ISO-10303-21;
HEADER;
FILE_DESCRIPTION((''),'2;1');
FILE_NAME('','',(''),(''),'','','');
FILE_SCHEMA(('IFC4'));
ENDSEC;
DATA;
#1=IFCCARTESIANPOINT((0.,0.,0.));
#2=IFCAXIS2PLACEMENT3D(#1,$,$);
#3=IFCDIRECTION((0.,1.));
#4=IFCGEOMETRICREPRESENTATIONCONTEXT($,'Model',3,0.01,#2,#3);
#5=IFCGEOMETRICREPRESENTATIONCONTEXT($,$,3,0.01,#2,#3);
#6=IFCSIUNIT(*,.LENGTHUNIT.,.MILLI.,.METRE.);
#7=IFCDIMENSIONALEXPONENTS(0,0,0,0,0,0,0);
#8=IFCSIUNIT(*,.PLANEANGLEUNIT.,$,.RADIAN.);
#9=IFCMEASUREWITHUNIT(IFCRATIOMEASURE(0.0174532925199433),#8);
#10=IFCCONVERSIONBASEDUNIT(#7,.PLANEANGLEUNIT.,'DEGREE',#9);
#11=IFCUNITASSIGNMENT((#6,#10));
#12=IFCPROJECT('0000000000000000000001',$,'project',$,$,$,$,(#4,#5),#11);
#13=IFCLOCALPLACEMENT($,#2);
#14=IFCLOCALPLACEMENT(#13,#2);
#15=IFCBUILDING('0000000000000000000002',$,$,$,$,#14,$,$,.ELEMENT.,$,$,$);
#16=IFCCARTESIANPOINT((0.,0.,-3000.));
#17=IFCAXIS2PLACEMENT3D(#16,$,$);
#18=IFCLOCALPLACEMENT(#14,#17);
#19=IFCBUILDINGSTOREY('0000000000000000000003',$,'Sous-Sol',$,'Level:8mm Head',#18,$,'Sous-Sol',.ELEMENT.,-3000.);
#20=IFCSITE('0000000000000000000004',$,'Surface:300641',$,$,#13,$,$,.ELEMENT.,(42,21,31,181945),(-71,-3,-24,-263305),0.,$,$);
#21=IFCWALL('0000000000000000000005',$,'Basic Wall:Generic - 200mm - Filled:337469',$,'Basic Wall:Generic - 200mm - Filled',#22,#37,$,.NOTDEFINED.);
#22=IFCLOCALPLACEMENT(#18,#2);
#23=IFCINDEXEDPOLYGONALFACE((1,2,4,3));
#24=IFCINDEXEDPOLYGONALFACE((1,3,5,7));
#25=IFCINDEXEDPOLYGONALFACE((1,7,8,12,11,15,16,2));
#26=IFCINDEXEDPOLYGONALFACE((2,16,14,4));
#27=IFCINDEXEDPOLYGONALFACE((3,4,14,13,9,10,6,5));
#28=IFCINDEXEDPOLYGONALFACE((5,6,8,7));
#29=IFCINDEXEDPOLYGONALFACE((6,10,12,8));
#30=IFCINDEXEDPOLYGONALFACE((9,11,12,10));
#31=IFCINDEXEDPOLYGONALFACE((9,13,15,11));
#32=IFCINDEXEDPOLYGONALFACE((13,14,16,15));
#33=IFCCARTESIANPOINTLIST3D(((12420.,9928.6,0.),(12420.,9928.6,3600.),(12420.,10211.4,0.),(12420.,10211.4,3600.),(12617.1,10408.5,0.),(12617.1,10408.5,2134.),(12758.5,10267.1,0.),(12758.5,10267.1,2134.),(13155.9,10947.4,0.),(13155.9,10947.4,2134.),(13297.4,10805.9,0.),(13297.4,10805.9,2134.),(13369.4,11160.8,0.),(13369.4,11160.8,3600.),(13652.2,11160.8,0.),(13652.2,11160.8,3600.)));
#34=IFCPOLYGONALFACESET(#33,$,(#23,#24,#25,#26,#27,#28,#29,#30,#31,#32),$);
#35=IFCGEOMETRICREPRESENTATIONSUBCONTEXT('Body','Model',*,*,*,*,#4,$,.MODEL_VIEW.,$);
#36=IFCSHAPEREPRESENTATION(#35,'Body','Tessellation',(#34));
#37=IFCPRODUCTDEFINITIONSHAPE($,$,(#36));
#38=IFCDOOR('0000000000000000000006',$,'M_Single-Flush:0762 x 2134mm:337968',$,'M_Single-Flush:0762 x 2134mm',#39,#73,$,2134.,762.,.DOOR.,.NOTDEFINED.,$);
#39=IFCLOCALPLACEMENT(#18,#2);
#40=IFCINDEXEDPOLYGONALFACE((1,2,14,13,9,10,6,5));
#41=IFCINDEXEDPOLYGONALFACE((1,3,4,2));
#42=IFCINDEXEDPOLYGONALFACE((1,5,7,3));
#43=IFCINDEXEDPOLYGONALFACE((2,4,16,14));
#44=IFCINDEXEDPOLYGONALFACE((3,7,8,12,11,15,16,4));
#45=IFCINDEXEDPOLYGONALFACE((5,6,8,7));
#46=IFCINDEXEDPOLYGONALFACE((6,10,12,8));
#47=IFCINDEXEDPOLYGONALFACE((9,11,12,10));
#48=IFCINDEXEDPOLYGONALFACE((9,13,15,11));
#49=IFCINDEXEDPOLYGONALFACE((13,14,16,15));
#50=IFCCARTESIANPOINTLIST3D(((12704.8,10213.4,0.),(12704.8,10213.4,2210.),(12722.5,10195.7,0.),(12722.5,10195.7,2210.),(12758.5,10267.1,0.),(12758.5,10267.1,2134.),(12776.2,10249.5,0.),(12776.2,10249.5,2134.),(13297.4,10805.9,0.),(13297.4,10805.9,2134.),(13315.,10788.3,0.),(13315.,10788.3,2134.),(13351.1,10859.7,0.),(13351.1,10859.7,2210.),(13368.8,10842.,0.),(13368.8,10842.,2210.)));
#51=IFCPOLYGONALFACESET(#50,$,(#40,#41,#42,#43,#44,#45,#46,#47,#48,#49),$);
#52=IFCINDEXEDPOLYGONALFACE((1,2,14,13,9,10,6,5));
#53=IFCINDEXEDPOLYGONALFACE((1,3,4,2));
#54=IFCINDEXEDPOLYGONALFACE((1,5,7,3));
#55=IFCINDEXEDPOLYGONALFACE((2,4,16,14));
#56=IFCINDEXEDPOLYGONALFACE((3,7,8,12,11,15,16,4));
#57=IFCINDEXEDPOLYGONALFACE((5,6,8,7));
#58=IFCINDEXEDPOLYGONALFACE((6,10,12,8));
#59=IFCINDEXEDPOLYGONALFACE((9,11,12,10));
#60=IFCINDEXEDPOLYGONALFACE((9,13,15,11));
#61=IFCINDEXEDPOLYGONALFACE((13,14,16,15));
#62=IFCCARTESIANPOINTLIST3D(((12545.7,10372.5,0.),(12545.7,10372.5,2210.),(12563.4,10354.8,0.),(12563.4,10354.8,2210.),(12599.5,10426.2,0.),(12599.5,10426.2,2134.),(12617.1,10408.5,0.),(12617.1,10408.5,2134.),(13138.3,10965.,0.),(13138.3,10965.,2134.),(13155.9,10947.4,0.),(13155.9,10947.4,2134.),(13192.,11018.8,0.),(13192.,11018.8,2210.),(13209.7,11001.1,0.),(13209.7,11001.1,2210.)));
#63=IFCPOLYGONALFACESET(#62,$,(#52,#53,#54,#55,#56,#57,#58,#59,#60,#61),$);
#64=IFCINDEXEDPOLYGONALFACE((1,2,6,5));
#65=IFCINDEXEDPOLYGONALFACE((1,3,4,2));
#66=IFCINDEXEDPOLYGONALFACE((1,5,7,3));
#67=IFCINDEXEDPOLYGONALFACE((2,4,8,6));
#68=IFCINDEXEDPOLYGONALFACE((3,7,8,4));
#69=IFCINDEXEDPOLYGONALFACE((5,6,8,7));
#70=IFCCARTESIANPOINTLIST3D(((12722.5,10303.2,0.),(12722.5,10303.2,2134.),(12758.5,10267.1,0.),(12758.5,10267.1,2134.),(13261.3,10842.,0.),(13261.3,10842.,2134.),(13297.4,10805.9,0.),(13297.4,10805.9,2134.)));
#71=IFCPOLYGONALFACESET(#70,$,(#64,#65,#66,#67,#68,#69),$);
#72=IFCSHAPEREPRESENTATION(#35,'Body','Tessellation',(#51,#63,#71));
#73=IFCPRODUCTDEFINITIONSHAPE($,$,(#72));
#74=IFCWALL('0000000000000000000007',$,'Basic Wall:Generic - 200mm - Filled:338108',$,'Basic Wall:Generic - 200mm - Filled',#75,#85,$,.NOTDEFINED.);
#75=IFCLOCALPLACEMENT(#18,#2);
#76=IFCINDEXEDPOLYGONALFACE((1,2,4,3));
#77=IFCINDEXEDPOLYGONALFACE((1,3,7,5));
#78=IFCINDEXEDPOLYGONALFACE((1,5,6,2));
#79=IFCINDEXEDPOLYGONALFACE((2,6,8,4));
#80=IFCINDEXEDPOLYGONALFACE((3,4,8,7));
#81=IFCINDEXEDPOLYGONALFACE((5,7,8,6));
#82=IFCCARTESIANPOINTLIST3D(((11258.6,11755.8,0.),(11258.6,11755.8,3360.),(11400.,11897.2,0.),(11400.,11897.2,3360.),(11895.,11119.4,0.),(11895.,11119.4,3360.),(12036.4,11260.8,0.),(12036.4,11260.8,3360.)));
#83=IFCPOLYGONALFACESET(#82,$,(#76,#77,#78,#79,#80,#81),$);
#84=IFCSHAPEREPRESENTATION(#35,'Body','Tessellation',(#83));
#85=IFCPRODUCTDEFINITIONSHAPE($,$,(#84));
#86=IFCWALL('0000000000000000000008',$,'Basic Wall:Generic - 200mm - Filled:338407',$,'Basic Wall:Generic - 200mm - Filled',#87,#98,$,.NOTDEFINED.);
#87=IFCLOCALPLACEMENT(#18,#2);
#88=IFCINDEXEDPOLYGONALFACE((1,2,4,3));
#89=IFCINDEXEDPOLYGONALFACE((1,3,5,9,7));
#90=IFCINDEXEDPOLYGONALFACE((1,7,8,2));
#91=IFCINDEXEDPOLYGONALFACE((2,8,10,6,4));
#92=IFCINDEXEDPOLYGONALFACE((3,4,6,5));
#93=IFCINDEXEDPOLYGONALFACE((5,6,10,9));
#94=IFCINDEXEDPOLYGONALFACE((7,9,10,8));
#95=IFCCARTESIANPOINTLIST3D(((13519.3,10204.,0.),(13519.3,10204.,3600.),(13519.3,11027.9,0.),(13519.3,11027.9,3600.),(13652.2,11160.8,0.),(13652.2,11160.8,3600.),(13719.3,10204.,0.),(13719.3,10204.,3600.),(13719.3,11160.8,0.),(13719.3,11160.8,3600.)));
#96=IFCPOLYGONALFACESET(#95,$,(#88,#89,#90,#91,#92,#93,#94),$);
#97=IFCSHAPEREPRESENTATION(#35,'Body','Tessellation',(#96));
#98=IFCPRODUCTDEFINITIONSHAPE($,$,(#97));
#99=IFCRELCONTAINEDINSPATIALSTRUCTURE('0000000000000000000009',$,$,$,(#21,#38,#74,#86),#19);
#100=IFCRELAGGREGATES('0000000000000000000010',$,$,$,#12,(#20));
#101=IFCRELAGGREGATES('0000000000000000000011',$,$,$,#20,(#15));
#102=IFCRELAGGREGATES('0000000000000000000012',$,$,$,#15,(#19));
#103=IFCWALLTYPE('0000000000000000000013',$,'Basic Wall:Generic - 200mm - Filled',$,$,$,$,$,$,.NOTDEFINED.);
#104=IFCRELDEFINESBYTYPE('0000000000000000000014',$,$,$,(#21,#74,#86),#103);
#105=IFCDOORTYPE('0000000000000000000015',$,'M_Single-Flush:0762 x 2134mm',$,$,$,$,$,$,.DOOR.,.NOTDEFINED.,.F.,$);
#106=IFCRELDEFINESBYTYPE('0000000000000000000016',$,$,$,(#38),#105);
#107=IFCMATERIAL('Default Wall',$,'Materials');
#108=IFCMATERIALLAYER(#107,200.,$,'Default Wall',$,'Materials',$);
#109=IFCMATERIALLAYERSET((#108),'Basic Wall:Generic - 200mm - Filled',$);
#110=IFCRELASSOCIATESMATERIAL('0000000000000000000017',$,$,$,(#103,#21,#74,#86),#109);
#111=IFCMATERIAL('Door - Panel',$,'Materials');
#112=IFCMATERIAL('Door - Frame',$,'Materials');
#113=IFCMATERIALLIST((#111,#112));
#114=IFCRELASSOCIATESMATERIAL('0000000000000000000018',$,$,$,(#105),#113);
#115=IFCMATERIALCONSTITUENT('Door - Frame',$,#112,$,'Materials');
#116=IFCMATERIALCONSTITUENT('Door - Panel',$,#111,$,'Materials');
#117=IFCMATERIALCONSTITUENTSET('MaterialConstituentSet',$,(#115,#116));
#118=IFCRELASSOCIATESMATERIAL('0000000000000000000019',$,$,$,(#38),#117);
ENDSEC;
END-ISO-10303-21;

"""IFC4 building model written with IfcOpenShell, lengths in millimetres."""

from ifc_helpers import new_model, entity, si_unit, converted_unit, direction, frame, frame_2d, origin, place, context, subcontext, project, spatial, polyline, rectangle, outline, extrude, clip, bounded_halfspace, source, transform, mapped, material, material_list, layer, layer_set, layer_usage, constituent, constituent_set, type_object, type_shapes, element, fill, save


model = new_model("IFC4")

# Units and contexts
model_context = context("Model", 3, precision=0.01, world=origin(), true_north=direction((0.0, 1.0)))
context_of_model = context(None, 3, precision=0.01, world=origin(), true_north=direction((0.0, 1.0)))
body_context = subcontext(model_context, "Body", "Model", "MODEL_VIEW")
ifc_project = project(units=[si_unit("LENGTHUNIT", "METRE", prefix="MILLI"), converted_unit("PLANEANGLEUNIT", "DEGREE", entity("IfcRatioMeasure", 0.0174532925199433), si_unit("PLANEANGLEUNIT", "RADIAN"), dimensions=[0, 0, 0, 0, 0, 0, 0])], contexts=[model_context, context_of_model])

# Site, building, storey
site_placement = place(None, origin())
site = spatial("IfcSite", under=ifc_project, at=site_placement, Name="Surface:300641", CompositionType="ELEMENT", RefLatitude=(42, 21, 31, 181945), RefLongitude=(-71, -3, -24, -263305), RefElevation=0.0)
building_placement = place(site_placement, origin())
building = spatial("IfcBuilding", under=site, at=building_placement, CompositionType="ELEMENT")
storey_placement = place(building_placement, frame((0.0, 0.0, -3000.0)))
storey = spatial("IfcBuildingStorey", under=building, at=storey_placement, Name="Sous-Sol", ObjectType="Level:8mm Head", LongName="Sous-Sol", CompositionType="ELEMENT", Elevation=-3000.0)

# Shared definitions
ifc_material_1 = material(Name="Default Wall", Category="Materials")

# Shared definitions
ifc_layer_1 = layer(ifc_material_1, 200.0, Name="Default Wall", Category="Materials")
ifc_layer_set_1 = layer_set([ifc_layer_1], Name="Basic Wall:Generic - 200mm - Filled")
wall_type_1 = type_object("IfcWallType", Name="Basic Wall:Generic - 200mm - Filled", PredefinedType="NOTDEFINED", material=ifc_layer_set_1)

# Wall, opening, door
ifc_layer_usage_1 = layer_usage(ifc_layer_set_1, "AXIS2", "NEGATIVE", 100.0)
wall_1_placement = place(storey_placement, frame((12349.3, 9999.3, 0.0), z_axis=(0.0, 0.0, 1.0), x_axis=(0.707107, 0.707107, 0.0)))
wall_1 = element("IfcWall", 1, at=wall_1_placement, inside=storey, type_object=wall_type_1, material=ifc_layer_usage_1, Name="Basic Wall:Generic - 200mm - Filled:337469", ObjectType="Basic Wall:Generic - 200mm - Filled", PredefinedType="NOTDEFINED", context=body_context, shape_type="SweptSolid", body=[
    extrude(outline(polyline([(0.0, -100.0), (1554.7, -100.0), (1742.7, -100.0), (1542.7, 100.0), (200.0, 100.0), (0.0, -100.0)])), origin(), (0.0, 0.0, 1.0), 3600.0),
])
opening_1_placement = place(wall_1_placement, frame((1240.8, 100.0, 0.0)))
opening_1 = element("IfcOpeningElement", 2, at=opening_1_placement, cuts=wall_1, ObjectType="Opening", PredefinedType="OPENING", context=body_context, shape_type="SweptSolid", body=[
    extrude(rectangle(XDim=762.0, YDim=2134.0, at=frame_2d((1067.0, 381.0), x_axis=(0.0, 1.0))), frame((0.0, 0.0, 0.0), z_axis=(0.0, -1.0, 0.0), x_axis=(0.0, 0.0, 1.0)), (0.0, 0.0, 1.0), 200.0),
])
ifc_material_2 = material(Name="Door - Frame", Category="Materials")
ifc_constituent_1 = constituent(ifc_material_2, Name="Door - Frame", Category="Materials")
ifc_material_3 = material(Name="Door - Panel", Category="Materials")
ifc_constituent_2 = constituent(ifc_material_3, Name="Door - Panel", Category="Materials")
ifc_constituent_set_1 = constituent_set(constituents=[ifc_constituent_1, ifc_constituent_2], Name="MaterialConstituentSet")
ifc_material_list_1 = material_list([ifc_material_3, ifc_material_2])
door_type = type_object("IfcDoorType", Name="M_Single-Flush:0762 x 2134mm", OperationType="NOTDEFINED", ParameterTakesPrecedence=False, PredefinedType="DOOR", material=ifc_material_list_1)
shared_shape_1 = source(origin(), body_context, "Body", "SweptSolid", [
    extrude(outline(polyline([(-457.0, -1124.0), (457.0, -1124.0), (457.0, 1086.0), (381.0, 1086.0), (381.0, -1048.0), (-381.0, -1048.0), (-381.0, 1086.0), (-457.0, 1086.0), (-457.0, -1124.0)])), frame((381.0, 200.0, 1086.0), z_axis=(0.0, 1.0, 0.0), x_axis=(1.0, 0.0, 0.0)), (0.0, 0.0, 1.0), 25.0),
    extrude(outline(polyline([(-1124.0, -457.0), (1086.0, -457.0), (1086.0, -381.0), (-1048.0, -381.0), (-1048.0, 381.0), (1086.0, 381.0), (1086.0, 457.0), (-1124.0, 457.0), (-1124.0, -457.0)])), frame((381.0, -25.0, 1086.0), z_axis=(0.0, 1.0, 0.0), x_axis=(0.0, 0.0, -1.0)), (0.0, 0.0, 1.0), 25.0),
    extrude(rectangle(XDim=51.0, YDim=762.0, at=frame_2d((0.0, 0.0), x_axis=(1.0, 0.0))), frame((381.0, 174.5, 0.0), z_axis=(0.0, 0.0, 1.0), x_axis=(0.0, 1.0, 0.0)), (0.0, 0.0, 1.0), 2134.0),
])
type_shapes(door_type, [shared_shape_1])
door_placement = place(opening_1_placement, frame((0.0, 0.0, 0.0), z_axis=(0.0, 0.0, 1.0), x_axis=(-1.0, 0.0, 0.0)))
door = element("IfcDoor", 3, at=door_placement, inside=storey, type_object=door_type, material=ifc_constituent_set_1, Name="M_Single-Flush:0762 x 2134mm:337968", ObjectType="M_Single-Flush:0762 x 2134mm", OperationType="NOTDEFINED", OverallHeight=2134.0, OverallWidth=762.0, PredefinedType="DOOR", context=body_context, shape_type="MappedRepresentation", body=[
    mapped(shared_shape_1, transform((0.0, 0.0, 0.0), scale=1.0)),
])
fill(opening_1, door)

# Walls
ifc_layer_usage_2 = layer_usage(ifc_layer_set_1, "AXIS2", "NEGATIVE", 100.0)
wall_2_placement = place(storey_placement, frame((11965.7, 11190.1, 0.0), z_axis=(0.0, 0.0, 1.0), x_axis=(-0.707107, 0.707107, 0.0)))
element("IfcWall", 4, at=wall_2_placement, inside=storey, type_object=wall_type_1, material=ifc_layer_usage_2, Name="Basic Wall:Generic - 200mm - Filled:338108", ObjectType="Basic Wall:Generic - 200mm - Filled", PredefinedType="NOTDEFINED", context=body_context, shape_type="Clipping", body=[
    clip(extrude(rectangle(XDim=900.0, YDim=200.0, at=frame_2d((450.0, 0.0), x_axis=(-1.0, 0.0))), origin(), (0.0, 0.0, 1.0), 3360.0), bounded_halfspace(frame((0.0, -100.0, 3360.0), z_axis=(0.0, 0.0, -1.0), x_axis=(-0.707107, 0.707107, 0.0)), True, frame((0.0, -100.0, 3360.0)), polyline([(0.0, 0.0), (200.0, 0.0), (900.0, 0.0), (900.0, 200.0), (0.0, 200.0), (0.0, 0.0)]))),
])
ifc_layer_usage_3 = layer_usage(ifc_layer_set_1, "AXIS2", "NEGATIVE", 100.0)
wall_3_placement = place(storey_placement, frame((13619.3, 11160.8, 0.0), z_axis=(0.0, 0.0, 1.0), x_axis=(0.0, -1.0, 0.0)))
element("IfcWall", 5, at=wall_3_placement, inside=storey, type_object=wall_type_1, material=ifc_layer_usage_3, Name="Basic Wall:Generic - 200mm - Filled:338407", ObjectType="Basic Wall:Generic - 200mm - Filled", PredefinedType="NOTDEFINED", context=body_context, shape_type="SweptSolid", body=[
    extrude(outline(polyline([(956.8, -100.0), (956.8, 100.0), (0.0, 100.0), (0.0, 32.9), (132.9, -100.0), (956.8, -100.0)])), origin(), (0.0, 0.0, 1.0), 3600.0),
])

save(model, "model.ifc")
